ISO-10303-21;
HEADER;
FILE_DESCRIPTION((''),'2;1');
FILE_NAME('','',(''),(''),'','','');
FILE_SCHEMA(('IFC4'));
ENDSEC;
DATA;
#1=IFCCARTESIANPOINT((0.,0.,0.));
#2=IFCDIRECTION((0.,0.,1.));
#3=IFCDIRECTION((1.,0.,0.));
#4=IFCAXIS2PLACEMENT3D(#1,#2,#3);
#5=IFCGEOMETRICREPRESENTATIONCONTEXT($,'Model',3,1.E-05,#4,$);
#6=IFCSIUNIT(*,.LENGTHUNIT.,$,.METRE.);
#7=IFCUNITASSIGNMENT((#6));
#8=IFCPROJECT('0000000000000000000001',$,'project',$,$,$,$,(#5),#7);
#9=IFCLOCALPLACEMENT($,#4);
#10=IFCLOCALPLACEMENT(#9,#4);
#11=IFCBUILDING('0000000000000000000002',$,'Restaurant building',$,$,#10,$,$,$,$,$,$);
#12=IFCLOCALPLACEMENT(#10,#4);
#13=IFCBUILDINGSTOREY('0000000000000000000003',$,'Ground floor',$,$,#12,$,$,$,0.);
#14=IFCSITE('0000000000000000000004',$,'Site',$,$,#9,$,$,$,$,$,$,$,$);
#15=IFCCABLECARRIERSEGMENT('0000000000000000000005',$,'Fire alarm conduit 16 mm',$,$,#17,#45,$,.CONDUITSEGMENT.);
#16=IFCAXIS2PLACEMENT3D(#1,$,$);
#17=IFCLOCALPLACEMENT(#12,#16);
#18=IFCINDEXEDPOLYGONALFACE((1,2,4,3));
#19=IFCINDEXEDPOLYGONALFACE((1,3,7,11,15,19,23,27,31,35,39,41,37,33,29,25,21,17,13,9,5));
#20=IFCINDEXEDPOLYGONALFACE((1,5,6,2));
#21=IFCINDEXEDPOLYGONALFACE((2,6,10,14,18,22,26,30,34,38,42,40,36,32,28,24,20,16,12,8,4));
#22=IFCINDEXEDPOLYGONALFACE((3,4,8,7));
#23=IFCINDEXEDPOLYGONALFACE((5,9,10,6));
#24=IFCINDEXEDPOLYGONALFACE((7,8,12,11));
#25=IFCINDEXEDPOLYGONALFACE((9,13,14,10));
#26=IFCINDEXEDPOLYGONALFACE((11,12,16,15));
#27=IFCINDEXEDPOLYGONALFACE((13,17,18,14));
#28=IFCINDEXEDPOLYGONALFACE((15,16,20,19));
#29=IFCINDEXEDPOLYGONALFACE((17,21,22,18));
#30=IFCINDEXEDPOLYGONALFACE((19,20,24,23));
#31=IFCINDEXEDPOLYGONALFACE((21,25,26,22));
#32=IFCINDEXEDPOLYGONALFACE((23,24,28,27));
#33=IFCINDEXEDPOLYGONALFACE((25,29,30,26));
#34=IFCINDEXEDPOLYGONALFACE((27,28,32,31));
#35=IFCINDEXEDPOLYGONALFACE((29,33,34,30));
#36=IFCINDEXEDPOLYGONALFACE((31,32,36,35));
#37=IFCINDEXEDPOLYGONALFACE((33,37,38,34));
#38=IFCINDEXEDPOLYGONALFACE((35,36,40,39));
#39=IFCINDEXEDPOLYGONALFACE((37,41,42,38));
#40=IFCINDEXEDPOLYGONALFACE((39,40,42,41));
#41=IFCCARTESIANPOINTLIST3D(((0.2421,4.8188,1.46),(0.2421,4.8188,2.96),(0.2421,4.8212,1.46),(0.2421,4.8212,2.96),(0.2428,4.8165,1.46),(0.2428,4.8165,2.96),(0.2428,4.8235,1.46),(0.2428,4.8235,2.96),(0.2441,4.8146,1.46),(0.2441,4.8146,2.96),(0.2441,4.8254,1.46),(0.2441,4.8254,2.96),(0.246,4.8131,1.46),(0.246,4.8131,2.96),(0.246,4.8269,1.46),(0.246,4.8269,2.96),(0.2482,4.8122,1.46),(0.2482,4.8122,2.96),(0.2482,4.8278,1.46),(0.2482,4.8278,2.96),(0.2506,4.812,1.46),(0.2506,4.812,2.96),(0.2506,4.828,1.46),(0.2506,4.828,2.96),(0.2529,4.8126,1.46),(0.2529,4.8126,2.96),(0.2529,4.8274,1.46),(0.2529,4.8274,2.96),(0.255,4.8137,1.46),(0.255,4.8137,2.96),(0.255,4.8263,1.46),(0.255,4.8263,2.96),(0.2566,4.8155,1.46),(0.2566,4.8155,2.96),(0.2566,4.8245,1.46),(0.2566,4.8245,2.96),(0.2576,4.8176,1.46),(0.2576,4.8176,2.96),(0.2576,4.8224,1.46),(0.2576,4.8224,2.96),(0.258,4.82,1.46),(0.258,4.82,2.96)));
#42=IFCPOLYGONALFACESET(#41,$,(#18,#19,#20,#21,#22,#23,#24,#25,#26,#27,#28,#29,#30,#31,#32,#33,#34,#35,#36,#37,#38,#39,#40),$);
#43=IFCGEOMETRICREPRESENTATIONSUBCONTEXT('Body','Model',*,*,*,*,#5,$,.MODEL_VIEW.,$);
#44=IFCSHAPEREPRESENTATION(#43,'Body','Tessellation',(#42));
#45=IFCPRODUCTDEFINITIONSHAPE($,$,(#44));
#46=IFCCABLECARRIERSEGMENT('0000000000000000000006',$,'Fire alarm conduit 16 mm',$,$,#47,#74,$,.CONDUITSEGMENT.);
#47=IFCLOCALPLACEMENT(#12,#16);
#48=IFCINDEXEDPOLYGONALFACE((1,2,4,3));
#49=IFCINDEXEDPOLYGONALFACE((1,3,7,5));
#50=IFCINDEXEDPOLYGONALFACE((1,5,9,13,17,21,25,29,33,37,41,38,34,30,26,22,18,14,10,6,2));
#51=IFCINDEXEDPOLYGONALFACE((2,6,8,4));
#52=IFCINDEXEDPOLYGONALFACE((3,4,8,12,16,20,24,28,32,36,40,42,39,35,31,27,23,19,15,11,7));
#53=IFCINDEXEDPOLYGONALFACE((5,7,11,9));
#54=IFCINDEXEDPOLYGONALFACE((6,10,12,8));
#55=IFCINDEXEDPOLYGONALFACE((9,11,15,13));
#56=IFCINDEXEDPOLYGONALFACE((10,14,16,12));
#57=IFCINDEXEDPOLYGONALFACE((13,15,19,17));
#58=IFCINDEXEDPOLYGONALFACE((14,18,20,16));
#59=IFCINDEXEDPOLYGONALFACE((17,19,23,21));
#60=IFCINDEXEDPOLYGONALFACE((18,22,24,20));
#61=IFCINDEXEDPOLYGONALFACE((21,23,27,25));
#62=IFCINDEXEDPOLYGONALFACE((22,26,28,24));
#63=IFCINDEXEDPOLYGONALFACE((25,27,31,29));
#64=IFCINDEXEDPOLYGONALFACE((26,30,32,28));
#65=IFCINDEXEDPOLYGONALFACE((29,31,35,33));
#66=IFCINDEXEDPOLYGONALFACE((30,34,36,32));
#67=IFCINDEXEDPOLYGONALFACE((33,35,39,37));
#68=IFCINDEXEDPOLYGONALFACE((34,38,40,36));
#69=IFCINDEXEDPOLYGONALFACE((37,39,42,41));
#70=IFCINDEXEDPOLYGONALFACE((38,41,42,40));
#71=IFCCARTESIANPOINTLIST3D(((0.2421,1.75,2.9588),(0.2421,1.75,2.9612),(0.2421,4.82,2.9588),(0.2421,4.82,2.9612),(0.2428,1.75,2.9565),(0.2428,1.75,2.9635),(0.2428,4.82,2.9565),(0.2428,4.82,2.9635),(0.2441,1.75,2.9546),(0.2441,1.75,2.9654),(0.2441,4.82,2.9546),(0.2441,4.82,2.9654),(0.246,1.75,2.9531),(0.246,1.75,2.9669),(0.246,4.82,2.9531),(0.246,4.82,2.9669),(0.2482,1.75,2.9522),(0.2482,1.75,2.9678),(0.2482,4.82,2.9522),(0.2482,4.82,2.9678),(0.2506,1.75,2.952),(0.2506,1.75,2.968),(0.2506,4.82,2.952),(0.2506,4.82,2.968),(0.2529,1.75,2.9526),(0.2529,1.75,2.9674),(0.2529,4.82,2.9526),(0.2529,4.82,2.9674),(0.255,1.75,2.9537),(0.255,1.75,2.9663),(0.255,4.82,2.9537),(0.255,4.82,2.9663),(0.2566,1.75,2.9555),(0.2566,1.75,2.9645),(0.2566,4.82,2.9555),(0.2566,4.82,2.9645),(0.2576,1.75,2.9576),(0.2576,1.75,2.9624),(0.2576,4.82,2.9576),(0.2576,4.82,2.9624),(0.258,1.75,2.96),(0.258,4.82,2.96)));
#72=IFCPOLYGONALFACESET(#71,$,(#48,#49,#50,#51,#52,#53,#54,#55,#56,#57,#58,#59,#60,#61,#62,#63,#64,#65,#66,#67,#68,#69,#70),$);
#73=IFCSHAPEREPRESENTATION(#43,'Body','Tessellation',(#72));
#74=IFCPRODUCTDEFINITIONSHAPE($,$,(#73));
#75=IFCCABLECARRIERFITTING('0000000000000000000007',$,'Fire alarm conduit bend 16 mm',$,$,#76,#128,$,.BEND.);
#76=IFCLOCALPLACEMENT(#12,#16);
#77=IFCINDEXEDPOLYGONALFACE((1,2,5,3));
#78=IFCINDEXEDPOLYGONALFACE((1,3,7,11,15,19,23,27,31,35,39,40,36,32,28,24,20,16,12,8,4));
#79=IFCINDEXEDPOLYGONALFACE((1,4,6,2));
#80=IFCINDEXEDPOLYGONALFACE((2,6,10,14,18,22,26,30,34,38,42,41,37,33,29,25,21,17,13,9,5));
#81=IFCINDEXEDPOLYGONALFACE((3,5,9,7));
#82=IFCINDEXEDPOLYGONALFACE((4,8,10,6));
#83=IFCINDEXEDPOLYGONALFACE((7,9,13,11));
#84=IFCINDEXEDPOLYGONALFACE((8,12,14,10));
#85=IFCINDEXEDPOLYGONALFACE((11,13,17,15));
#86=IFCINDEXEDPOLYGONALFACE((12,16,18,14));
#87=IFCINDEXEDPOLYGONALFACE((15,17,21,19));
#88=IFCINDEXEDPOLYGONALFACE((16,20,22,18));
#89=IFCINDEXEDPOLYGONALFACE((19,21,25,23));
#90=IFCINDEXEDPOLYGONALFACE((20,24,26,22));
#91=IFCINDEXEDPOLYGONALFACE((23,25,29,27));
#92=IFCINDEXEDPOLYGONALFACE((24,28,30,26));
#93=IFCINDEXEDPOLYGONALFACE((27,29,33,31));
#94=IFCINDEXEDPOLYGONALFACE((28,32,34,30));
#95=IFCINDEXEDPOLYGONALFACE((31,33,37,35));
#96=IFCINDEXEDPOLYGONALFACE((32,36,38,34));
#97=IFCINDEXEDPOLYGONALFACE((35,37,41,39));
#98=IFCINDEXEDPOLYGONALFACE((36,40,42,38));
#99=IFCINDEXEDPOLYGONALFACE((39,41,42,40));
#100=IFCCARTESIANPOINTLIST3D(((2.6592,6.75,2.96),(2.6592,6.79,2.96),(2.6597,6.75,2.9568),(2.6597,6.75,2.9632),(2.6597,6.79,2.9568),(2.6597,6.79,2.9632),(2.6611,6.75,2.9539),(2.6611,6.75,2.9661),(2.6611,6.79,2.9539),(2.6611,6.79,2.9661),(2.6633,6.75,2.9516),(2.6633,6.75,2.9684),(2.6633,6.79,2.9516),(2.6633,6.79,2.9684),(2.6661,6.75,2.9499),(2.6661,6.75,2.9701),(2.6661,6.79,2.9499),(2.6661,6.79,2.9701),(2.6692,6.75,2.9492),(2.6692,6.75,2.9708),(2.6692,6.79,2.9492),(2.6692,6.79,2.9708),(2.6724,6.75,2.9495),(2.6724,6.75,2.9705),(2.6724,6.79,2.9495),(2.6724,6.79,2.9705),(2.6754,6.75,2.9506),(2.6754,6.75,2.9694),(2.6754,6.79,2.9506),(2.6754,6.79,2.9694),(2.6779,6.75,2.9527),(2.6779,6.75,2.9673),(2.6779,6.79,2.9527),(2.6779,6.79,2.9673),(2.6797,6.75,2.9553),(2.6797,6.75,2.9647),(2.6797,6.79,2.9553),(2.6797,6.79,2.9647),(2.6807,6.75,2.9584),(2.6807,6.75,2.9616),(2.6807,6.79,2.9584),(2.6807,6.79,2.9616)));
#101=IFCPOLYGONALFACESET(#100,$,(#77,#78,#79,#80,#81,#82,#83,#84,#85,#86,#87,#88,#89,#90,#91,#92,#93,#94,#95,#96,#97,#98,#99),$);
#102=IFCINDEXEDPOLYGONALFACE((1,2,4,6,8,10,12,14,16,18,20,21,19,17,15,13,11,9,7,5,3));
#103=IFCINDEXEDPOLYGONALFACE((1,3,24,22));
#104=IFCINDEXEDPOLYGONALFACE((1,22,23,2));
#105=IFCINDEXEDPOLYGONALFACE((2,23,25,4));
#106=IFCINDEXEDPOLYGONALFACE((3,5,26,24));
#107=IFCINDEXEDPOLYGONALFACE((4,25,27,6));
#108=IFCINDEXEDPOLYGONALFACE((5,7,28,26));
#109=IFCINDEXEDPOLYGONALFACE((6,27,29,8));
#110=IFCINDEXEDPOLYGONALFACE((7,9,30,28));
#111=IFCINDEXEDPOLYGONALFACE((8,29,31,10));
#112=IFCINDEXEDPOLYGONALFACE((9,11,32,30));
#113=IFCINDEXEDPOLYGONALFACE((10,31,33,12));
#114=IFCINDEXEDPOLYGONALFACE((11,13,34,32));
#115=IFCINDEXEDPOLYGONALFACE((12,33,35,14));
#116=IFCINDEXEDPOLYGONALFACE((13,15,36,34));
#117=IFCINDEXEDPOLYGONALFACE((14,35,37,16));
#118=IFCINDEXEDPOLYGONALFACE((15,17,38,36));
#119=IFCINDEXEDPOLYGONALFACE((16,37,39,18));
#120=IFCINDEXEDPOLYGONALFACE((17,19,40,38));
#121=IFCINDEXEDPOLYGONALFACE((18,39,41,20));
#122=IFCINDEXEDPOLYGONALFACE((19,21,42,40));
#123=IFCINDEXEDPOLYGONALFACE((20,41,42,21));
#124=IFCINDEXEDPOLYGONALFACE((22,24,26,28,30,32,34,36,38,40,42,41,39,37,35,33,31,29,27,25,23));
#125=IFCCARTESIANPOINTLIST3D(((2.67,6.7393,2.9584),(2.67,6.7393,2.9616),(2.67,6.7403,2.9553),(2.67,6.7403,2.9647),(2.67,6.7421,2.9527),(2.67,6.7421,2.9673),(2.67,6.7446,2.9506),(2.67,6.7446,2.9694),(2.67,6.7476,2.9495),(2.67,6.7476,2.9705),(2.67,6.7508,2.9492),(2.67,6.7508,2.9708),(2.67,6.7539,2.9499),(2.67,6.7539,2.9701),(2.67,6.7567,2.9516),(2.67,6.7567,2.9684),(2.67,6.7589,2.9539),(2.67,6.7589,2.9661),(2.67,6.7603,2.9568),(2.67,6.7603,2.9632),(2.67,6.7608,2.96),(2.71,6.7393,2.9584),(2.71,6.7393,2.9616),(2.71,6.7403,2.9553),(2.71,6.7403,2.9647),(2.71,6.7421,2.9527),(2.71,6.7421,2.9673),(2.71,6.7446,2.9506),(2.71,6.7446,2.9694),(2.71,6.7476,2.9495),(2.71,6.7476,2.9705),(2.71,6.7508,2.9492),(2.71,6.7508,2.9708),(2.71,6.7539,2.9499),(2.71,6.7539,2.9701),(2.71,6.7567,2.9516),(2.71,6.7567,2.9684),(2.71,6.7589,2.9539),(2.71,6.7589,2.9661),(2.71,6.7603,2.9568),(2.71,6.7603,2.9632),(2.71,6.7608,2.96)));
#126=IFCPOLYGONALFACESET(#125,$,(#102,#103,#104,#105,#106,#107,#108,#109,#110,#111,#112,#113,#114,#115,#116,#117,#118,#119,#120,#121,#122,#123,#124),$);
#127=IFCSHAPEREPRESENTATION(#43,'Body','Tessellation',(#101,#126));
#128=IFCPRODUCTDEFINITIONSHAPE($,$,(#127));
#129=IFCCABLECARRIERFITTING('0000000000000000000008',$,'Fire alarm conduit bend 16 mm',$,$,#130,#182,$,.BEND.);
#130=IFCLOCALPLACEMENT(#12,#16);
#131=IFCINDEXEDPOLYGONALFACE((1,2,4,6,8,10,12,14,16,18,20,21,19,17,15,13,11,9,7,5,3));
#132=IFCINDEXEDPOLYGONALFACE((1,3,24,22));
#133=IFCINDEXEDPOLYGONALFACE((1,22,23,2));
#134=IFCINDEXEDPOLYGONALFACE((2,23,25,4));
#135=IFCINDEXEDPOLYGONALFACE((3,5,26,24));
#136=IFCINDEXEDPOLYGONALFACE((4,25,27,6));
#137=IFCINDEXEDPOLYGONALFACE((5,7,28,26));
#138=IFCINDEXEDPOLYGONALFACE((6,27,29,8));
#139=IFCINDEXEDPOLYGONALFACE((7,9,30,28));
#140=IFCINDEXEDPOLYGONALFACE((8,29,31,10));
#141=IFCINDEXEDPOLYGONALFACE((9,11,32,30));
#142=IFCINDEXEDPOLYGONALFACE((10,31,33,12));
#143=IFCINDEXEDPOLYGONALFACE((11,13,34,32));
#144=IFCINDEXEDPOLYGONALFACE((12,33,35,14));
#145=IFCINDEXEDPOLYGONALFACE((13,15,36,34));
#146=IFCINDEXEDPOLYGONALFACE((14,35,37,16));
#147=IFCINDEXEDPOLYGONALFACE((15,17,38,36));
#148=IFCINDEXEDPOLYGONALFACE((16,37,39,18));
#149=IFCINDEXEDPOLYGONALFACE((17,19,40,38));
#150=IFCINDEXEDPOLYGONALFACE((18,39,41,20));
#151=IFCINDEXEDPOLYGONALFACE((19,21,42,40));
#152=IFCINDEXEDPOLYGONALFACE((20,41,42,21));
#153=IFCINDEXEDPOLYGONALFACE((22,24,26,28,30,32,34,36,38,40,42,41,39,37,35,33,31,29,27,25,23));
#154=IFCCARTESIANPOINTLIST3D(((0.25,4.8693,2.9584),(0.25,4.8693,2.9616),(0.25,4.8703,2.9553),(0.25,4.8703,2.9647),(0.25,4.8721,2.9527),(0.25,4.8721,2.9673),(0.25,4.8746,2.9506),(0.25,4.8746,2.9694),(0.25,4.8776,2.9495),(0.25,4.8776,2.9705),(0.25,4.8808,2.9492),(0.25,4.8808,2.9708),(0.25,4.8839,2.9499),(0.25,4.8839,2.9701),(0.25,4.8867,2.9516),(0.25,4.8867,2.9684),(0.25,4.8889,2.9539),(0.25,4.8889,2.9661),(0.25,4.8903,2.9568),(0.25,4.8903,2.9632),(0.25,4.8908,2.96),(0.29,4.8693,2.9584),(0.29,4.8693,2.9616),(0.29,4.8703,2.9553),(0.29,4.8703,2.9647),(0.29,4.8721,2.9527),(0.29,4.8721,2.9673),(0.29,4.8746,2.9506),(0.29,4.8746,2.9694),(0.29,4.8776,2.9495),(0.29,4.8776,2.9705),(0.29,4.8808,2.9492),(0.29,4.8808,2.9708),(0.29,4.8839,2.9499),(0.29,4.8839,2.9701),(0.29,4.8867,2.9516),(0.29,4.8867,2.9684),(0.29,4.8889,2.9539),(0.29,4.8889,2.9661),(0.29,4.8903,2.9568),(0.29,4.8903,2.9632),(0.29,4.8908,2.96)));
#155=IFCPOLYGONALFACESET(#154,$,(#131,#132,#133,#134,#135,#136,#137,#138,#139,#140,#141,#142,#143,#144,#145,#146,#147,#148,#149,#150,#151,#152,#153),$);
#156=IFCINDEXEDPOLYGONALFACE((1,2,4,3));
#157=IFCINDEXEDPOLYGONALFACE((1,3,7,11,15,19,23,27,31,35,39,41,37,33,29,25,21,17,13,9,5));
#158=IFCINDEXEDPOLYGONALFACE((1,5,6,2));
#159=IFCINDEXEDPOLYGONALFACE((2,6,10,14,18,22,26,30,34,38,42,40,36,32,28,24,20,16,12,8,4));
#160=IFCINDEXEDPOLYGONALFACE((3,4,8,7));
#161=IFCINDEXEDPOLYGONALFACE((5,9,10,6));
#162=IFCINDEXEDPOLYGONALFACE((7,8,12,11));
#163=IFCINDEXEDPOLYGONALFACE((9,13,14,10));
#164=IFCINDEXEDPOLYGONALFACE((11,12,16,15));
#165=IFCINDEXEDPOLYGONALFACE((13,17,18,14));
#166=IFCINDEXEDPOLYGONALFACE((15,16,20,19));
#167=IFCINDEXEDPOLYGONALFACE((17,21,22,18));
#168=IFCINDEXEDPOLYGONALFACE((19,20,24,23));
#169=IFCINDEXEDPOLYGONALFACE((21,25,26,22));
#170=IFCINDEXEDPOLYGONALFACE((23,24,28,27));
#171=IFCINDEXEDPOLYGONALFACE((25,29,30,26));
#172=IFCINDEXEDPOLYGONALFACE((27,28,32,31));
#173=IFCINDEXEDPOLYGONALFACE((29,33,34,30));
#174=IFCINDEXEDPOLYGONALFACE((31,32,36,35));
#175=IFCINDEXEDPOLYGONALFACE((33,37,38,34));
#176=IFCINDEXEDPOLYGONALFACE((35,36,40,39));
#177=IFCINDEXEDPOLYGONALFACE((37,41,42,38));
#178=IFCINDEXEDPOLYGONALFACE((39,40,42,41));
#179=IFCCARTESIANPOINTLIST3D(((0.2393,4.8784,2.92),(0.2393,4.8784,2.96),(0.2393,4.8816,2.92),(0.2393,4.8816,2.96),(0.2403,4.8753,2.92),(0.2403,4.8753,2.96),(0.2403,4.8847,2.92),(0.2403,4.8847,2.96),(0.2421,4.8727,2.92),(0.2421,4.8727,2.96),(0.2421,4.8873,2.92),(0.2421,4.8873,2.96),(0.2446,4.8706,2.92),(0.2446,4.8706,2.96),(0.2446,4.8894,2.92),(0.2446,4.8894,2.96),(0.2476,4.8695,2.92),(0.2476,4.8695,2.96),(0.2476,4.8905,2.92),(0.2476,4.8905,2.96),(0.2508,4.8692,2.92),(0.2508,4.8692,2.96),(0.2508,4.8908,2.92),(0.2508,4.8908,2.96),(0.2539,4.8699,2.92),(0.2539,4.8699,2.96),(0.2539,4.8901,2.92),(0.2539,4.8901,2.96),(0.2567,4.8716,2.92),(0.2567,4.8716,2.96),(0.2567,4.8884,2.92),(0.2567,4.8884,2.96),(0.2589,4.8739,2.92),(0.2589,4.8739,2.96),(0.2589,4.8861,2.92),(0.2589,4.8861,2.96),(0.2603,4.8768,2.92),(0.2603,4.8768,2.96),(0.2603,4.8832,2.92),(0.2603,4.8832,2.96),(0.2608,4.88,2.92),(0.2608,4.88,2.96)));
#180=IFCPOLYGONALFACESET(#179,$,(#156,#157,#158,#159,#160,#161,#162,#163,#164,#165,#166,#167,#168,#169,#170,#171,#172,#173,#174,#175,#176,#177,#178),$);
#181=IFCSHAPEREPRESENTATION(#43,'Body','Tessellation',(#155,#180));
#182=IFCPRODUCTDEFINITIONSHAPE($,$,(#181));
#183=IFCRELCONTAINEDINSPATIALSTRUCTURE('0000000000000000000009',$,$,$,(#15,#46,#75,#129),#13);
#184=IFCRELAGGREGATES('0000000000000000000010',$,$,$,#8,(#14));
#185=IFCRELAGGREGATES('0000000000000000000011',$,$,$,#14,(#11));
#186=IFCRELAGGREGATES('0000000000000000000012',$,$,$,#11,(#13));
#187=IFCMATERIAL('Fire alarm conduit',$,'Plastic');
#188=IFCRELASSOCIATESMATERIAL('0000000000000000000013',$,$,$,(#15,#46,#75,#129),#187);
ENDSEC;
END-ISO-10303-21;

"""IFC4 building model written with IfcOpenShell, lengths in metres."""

from ifc_helpers import new_model, si_unit, frame, origin, origin_with_axes, origin_2d, place, context, subcontext, project, spatial, circle, extrude, material, element, save


model = new_model("IFC4")

# Units and contexts
model_context = context("Model", 3, precision=1e-05, world=origin_with_axes())
body_context = subcontext(model_context, "Body", "Model", "MODEL_VIEW")
ifc_project = project(units=[si_unit("LENGTHUNIT", "METRE")], contexts=[model_context])

# Site, building, storey
site_placement = place(None, origin_with_axes())
site = spatial("IfcSite", under=ifc_project, at=site_placement, Name="Site")
building_placement = place(site_placement, origin_with_axes())
building = spatial("IfcBuilding", under=site, at=building_placement, Name="Restaurant building")
storey_placement = place(building_placement, origin_with_axes())
storey = spatial("IfcBuildingStorey", under=building, at=storey_placement, Name="Ground floor", Elevation=0.0)

# Cable carrier segments
ifc_material_1 = material(Name="Fire alarm conduit", Category="Plastic")
cable_carrier_segment_1_placement = place(storey_placement, frame((0.25, 4.82, 1.46)))
element("IfcCableCarrierSegment", 1, at=cable_carrier_segment_1_placement, inside=storey, material=ifc_material_1, Name="Fire alarm conduit 16 mm", PredefinedType="CONDUITSEGMENT", context=body_context, shape_type="SweptSolid", body=[
    extrude(circle(Radius=0.008, at=origin_2d()), origin(), (0.0, 0.0, 1.0), 1.5),
])
cable_carrier_segment_2_placement = place(storey_placement, frame((0.25, 4.82, 2.96)))
element("IfcCableCarrierSegment", 2, at=cable_carrier_segment_2_placement, inside=storey, material=ifc_material_1, Name="Fire alarm conduit 16 mm", PredefinedType="CONDUITSEGMENT", context=body_context, shape_type="SweptSolid", body=[
    extrude(circle(Radius=0.008, at=origin_2d()), frame((0.0, 0.0, 0.0), z_axis=(0.0, -1.0, 0.0), x_axis=(1.0, 0.0, 0.0)), (0.0, 0.0, 1.0), 3.07),
])

# Cable carrier fittings
cable_carrier_fitting_1_placement = place(storey_placement, frame((2.67, 6.75, 2.96)))
element("IfcCableCarrierFitting", 3, at=cable_carrier_fitting_1_placement, inside=storey, material=ifc_material_1, Name="Fire alarm conduit bend 16 mm", PredefinedType="BEND", context=body_context, shape_type="SweptSolid", body=[
    extrude(circle(Radius=0.0108, at=origin_2d()), frame((0.0, 0.0, 0.0), z_axis=(0.0, 1.0, 0.0), x_axis=(-1.0, 0.0, 0.0)), (0.0, 0.0, 1.0), 0.04),
    extrude(circle(Radius=0.0108, at=origin_2d()), frame((0.0, 0.0, 0.0), z_axis=(1.0, 0.0, 0.0), x_axis=(0.0, 1.0, 0.0)), (0.0, 0.0, 1.0), 0.04),
])
cable_carrier_fitting_2_placement = place(storey_placement, frame((0.25, 4.88, 2.96)))
element("IfcCableCarrierFitting", 4, at=cable_carrier_fitting_2_placement, inside=storey, material=ifc_material_1, Name="Fire alarm conduit bend 16 mm", PredefinedType="BEND", context=body_context, shape_type="SweptSolid", body=[
    extrude(circle(Radius=0.0108, at=origin_2d()), frame((0.0, 0.0, 0.0), z_axis=(1.0, 0.0, 0.0), x_axis=(0.0, 1.0, 0.0)), (0.0, 0.0, 1.0), 0.04),
    extrude(circle(Radius=0.0108, at=origin_2d()), frame((0.0, 0.0, 0.0), z_axis=(0.0, 0.0, -1.0), x_axis=(1.0, 0.0, 0.0)), (0.0, 0.0, 1.0), 0.04),
])

save(model, "model.ifc")
